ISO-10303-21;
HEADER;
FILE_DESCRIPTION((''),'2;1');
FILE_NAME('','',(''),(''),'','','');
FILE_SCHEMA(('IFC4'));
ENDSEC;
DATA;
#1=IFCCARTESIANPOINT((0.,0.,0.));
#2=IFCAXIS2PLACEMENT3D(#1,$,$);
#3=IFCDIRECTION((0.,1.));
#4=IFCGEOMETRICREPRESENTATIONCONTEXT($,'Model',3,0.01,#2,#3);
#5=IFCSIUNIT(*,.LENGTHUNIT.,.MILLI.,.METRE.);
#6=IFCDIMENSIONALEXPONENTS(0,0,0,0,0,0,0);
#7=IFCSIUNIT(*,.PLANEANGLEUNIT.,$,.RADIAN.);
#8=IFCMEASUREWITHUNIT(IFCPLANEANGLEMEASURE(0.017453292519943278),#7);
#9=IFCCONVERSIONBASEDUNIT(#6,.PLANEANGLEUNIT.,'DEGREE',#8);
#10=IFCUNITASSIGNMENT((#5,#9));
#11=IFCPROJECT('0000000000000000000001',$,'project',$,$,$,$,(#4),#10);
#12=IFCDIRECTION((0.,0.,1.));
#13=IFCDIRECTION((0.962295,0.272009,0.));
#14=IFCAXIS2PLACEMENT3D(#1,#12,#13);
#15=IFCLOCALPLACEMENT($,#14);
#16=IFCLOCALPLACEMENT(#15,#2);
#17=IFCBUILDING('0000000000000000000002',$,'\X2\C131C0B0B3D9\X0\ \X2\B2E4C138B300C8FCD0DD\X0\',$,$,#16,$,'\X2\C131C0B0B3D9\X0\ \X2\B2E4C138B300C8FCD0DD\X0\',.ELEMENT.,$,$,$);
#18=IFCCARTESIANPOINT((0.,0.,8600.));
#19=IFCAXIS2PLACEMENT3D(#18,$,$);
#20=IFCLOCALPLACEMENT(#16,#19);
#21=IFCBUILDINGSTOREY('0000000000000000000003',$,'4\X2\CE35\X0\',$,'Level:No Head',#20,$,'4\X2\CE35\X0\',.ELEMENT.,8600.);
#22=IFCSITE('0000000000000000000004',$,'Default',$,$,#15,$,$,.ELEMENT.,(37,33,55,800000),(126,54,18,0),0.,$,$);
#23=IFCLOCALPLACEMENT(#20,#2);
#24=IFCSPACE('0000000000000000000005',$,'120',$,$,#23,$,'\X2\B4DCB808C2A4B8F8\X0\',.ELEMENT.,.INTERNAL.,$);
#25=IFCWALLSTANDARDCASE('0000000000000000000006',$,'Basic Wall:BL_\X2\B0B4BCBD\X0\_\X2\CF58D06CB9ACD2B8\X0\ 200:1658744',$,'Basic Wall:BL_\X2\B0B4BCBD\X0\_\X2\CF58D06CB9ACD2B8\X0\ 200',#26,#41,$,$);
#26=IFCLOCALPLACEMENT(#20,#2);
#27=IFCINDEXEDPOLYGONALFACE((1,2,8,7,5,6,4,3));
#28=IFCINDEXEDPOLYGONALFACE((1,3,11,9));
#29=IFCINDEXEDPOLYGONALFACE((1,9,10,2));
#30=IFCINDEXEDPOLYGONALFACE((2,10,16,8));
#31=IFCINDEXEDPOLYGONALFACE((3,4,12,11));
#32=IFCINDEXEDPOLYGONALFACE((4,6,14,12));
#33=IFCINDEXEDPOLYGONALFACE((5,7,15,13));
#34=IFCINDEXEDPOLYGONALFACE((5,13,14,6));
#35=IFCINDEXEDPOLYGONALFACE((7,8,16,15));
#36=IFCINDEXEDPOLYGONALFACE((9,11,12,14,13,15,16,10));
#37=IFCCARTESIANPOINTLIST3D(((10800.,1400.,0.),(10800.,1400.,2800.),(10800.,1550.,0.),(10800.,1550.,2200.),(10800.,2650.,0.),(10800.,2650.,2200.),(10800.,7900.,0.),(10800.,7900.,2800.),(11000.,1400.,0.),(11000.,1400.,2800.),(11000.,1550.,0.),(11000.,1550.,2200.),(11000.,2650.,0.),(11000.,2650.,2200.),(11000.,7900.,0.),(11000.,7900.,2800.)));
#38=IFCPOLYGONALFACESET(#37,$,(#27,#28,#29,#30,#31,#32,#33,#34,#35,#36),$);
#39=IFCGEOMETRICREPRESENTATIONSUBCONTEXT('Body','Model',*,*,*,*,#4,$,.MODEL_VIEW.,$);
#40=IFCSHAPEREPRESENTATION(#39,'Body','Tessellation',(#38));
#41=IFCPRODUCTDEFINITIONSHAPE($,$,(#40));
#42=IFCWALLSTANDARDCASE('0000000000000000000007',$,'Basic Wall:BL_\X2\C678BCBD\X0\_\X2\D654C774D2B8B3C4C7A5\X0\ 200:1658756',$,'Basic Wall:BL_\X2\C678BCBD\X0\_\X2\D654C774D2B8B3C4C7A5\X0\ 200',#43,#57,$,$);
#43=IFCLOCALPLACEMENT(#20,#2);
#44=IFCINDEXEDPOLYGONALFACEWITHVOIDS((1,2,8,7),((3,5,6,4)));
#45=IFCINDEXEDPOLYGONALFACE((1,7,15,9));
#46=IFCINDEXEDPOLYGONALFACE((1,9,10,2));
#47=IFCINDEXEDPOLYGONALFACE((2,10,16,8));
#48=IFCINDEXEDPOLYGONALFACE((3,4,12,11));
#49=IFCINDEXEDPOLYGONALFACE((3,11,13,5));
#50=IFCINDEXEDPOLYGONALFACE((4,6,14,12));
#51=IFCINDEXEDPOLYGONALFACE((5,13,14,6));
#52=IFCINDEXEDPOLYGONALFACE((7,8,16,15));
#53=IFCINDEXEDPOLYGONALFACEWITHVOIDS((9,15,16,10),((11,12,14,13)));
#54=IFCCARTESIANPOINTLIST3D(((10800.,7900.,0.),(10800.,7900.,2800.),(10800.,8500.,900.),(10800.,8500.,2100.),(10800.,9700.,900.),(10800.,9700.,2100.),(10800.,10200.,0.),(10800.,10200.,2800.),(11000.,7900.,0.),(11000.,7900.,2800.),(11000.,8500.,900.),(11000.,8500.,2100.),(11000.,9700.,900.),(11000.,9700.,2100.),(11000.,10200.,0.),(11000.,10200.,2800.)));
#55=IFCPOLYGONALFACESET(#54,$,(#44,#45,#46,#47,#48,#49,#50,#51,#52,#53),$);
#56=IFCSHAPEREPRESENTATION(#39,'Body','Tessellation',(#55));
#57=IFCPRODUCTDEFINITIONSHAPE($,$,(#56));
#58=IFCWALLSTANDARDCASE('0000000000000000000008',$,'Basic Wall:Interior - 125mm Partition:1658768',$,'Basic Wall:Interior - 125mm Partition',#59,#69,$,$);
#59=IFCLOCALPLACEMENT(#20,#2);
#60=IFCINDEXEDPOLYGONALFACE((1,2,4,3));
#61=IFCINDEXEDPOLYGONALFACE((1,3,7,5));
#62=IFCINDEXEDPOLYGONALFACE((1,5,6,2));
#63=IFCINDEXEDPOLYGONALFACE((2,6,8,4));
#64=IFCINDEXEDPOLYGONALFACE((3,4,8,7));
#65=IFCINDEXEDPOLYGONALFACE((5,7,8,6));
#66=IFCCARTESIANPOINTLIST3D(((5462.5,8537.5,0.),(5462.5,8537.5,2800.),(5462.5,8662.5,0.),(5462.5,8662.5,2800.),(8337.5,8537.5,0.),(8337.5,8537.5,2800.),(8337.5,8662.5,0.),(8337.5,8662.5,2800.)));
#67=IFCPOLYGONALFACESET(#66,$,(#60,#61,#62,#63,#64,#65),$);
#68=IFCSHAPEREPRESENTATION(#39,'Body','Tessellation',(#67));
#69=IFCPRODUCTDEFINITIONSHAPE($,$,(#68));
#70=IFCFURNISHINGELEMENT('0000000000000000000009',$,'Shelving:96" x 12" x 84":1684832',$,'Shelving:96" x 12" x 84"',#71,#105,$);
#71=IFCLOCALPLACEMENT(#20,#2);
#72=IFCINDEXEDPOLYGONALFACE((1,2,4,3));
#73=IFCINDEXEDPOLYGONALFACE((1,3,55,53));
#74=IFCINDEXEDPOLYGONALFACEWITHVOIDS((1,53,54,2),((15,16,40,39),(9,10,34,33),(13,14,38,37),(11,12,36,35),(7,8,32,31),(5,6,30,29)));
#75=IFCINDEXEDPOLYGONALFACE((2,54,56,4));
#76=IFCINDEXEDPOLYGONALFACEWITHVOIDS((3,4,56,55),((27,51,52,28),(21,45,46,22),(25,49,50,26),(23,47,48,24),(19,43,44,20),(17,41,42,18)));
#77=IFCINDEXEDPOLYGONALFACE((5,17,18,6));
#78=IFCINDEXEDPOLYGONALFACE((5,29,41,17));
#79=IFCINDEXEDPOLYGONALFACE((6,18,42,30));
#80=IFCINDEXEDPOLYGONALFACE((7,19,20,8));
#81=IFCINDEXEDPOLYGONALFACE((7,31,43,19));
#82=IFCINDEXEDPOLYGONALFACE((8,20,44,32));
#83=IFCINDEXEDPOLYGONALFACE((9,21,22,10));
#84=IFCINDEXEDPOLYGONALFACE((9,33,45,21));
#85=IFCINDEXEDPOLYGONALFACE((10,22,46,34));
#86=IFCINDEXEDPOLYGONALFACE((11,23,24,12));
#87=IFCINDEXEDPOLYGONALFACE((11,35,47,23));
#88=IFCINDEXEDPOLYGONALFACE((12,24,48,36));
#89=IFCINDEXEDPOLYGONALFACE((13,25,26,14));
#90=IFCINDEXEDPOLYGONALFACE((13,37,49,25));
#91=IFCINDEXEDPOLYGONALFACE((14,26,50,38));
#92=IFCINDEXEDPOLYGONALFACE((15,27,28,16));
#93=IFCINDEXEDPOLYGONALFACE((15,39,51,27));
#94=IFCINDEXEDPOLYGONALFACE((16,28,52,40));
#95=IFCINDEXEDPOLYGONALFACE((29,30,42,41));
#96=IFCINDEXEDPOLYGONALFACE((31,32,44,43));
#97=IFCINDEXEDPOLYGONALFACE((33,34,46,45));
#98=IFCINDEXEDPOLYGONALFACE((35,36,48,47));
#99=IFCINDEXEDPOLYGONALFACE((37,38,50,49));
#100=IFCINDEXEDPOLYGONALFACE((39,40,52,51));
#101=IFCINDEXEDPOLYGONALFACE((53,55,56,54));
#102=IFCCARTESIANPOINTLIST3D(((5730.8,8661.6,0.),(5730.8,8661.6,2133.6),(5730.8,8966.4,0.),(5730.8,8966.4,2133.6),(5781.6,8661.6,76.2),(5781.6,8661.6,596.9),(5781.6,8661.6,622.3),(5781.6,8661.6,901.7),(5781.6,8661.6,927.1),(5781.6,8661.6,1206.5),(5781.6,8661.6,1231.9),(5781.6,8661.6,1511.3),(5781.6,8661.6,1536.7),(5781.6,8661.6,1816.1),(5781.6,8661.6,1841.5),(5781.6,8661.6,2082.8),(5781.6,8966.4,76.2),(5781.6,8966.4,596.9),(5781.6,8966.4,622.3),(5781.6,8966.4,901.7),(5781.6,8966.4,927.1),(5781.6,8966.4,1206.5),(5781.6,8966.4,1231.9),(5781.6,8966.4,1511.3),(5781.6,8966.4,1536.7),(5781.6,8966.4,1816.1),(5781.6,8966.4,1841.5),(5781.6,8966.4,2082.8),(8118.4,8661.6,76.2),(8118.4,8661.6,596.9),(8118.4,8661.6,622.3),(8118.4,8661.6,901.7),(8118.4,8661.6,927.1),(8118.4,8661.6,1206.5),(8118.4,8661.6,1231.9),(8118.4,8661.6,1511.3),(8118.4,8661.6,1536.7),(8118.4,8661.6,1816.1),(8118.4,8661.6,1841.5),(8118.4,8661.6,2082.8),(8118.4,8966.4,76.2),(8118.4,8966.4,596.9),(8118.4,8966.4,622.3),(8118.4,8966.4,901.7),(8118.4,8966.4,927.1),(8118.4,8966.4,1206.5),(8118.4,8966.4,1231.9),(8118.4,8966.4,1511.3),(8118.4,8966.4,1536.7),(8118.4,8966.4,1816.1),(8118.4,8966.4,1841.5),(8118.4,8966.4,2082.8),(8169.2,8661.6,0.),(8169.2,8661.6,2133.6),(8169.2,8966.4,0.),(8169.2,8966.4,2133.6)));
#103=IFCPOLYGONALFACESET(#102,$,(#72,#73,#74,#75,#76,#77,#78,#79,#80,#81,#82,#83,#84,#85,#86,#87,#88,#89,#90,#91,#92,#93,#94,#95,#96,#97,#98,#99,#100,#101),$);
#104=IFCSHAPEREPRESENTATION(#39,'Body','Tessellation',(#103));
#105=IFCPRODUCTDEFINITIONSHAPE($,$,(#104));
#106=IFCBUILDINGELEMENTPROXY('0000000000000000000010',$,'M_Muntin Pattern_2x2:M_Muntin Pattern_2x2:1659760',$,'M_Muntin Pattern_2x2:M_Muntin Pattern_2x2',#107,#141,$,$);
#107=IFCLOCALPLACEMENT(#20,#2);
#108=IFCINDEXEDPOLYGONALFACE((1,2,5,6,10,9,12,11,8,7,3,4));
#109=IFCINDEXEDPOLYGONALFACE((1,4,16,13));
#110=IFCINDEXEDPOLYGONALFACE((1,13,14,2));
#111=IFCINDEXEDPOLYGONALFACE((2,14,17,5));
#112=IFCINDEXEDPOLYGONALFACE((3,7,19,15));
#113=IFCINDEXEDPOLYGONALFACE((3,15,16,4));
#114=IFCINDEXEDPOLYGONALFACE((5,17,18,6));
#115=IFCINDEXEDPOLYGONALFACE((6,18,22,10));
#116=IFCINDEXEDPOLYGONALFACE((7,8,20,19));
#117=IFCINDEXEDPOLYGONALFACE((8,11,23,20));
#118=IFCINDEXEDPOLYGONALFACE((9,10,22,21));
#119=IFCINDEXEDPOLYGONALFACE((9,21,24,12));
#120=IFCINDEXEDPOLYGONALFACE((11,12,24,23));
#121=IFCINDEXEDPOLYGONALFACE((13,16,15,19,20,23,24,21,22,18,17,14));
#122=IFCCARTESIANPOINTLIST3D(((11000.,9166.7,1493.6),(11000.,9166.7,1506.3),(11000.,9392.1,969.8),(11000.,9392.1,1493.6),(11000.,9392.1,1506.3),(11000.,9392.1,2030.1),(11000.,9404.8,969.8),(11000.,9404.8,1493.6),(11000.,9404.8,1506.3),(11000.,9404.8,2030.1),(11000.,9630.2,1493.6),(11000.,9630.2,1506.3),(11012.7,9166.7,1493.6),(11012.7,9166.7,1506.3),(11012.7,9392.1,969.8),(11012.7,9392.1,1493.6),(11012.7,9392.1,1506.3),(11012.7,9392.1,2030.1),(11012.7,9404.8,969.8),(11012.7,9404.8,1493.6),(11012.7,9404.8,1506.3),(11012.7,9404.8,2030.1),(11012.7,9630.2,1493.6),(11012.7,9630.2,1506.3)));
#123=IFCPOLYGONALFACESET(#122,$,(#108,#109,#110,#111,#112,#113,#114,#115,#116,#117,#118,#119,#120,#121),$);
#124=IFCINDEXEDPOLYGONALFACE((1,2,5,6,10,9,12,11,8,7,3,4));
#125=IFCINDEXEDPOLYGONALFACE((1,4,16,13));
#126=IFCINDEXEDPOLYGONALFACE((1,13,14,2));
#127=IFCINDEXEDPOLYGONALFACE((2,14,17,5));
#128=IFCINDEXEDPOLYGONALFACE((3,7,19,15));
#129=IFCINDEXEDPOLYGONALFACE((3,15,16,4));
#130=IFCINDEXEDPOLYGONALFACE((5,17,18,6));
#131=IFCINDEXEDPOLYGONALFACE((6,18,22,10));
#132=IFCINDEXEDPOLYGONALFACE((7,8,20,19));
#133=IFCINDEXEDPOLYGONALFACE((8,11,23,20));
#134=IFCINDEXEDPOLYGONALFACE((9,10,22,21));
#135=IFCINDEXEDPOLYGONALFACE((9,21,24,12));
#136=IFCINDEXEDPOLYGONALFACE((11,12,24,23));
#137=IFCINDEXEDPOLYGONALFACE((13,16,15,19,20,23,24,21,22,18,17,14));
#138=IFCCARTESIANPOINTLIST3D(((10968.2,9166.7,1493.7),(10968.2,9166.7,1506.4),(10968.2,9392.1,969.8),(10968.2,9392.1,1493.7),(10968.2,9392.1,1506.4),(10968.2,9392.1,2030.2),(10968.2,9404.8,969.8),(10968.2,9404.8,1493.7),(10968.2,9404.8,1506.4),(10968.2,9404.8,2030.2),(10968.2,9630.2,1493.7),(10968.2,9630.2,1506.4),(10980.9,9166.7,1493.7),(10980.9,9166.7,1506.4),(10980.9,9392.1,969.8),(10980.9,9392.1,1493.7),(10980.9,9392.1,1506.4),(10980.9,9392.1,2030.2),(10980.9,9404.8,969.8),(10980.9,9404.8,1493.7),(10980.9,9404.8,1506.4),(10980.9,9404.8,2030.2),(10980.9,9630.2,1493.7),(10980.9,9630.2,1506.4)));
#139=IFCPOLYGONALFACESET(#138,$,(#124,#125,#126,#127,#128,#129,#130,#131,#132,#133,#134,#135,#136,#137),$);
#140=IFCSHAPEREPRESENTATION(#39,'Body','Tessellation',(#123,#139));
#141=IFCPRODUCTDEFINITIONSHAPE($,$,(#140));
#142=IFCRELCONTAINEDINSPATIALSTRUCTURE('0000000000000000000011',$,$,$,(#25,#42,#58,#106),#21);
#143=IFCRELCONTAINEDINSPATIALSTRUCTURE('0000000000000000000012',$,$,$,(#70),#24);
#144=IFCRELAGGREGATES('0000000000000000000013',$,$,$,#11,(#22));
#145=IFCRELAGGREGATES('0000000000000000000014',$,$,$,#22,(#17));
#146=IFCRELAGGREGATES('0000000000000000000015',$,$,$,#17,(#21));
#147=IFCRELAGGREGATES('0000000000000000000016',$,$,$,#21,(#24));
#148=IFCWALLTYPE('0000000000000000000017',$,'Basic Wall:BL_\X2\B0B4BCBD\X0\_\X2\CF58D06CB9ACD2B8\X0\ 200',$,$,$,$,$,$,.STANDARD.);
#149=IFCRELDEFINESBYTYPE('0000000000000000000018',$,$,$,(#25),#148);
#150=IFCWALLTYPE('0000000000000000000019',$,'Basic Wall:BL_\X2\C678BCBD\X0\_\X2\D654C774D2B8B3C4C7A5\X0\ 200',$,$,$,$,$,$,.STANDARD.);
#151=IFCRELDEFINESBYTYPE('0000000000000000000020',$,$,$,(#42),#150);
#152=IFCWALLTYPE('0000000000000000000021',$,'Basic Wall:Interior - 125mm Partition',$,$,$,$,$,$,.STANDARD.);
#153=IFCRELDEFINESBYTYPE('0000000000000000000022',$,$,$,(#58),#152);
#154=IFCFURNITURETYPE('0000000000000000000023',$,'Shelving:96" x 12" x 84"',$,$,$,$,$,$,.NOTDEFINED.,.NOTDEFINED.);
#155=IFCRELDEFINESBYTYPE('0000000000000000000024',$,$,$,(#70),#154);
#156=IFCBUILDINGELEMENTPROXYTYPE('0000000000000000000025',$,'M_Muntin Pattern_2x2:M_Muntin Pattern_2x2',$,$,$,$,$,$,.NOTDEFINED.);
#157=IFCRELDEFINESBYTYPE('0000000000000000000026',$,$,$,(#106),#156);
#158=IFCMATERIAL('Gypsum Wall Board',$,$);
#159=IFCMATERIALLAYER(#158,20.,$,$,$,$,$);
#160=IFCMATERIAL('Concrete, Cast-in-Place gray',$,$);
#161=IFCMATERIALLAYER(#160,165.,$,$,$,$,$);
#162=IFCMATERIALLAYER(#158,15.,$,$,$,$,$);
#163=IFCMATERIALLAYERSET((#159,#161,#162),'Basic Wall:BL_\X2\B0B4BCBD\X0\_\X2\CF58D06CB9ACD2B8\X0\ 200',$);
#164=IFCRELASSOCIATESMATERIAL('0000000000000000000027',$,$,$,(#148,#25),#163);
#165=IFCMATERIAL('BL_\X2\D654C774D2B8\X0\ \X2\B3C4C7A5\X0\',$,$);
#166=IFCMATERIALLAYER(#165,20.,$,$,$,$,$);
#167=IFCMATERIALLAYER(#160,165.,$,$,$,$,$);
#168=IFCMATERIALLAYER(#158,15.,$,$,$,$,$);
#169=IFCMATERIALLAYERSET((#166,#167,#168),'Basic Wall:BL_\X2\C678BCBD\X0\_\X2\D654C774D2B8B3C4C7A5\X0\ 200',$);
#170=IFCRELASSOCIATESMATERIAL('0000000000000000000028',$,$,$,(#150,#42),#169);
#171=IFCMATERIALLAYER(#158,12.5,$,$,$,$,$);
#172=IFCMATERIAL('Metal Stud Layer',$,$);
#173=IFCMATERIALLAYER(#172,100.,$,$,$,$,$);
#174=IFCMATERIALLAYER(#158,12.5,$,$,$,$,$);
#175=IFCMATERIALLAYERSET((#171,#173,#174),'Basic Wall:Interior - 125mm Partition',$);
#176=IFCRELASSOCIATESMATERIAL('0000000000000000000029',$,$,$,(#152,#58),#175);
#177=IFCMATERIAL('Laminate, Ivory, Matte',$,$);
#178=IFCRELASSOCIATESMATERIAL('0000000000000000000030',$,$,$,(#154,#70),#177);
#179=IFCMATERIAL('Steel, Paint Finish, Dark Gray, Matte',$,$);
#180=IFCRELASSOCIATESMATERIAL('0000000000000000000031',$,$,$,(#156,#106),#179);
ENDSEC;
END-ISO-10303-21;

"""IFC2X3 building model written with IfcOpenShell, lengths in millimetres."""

from ifc_helpers import new_model, entity, si_unit, converted_unit, direction, frame, frame_2d, origin, place, context, subcontext, project, spatial, polyline, rectangle, outline, extrude, source, transform, mapped, material, layer, layer_set, layer_usage, type_object, type_shapes, element, save


model = new_model("IFC2X3")

# Units and contexts
model_context = context("Model", 3, precision=0.01, world=origin(), true_north=direction((0.0, 1.0)))
body_context = subcontext(model_context, "Body", "Model", "MODEL_VIEW")
ifc_project = project(units=[si_unit("LENGTHUNIT", "METRE", prefix="MILLI"), converted_unit("PLANEANGLEUNIT", "DEGREE", entity("IfcPlaneAngleMeasure", 0.017453292519943278), si_unit("PLANEANGLEUNIT", "RADIAN"), dimensions=[0, 0, 0, 0, 0, 0, 0])], contexts=[model_context])

# Site, building, storey
site_placement = place(None, frame((0.0, 0.0, 0.0), z_axis=(0.0, 0.0, 1.0), x_axis=(0.962295, 0.272009, 0.0)))
site = spatial("IfcSite", under=ifc_project, at=site_placement, Name="Default", CompositionType="ELEMENT", RefLatitude=(37, 33, 55, 800000), RefLongitude=(126, 54, 18, 0), RefElevation=0.0)
building_placement = place(site_placement, origin())
building = spatial("IfcBuilding", under=site, at=building_placement, Name="성산동 다세대주택", LongName="성산동 다세대주택", CompositionType="ELEMENT")
storey_placement = place(building_placement, frame((0.0, 0.0, 8600.0)))
storey = spatial("IfcBuildingStorey", under=building, at=storey_placement, Name="4층", ObjectType="Level:No Head", LongName="4층", CompositionType="ELEMENT", Elevation=8600.0)

# Wall, openings
ifc_material_1 = material(Name="Gypsum Wall Board")
ifc_layer_1 = layer(ifc_material_1, 20.0)
ifc_material_2 = material(Name="Concrete, Cast-in-Place gray")
ifc_layer_2 = layer(ifc_material_2, 165.0)
ifc_layer_3 = layer(ifc_material_1, 15.0)
ifc_layer_set_1 = layer_set([ifc_layer_1, ifc_layer_2, ifc_layer_3], Name="Basic Wall:BL_내벽_콘크리트 200")
ifc_layer_usage_1 = layer_usage(ifc_layer_set_1, "AXIS2", "NEGATIVE", 100.0)
wall_type_1 = type_object("IfcWallType", Name="Basic Wall:BL_내벽_콘크리트 200", PredefinedType="STANDARD", material=ifc_layer_set_1)
wall_1_placement = place(storey_placement, frame((10900.0, 7900.0, 0.0), z_axis=(0.0, 0.0, 1.0), x_axis=(0.0, -1.0, 0.0)))
wall_1 = element("IfcWallStandardCase", 1, at=wall_1_placement, inside=storey, type_object=wall_type_1, material=ifc_layer_usage_1, Name="Basic Wall:BL_내벽_콘크리트 200:1658744", ObjectType="Basic Wall:BL_내벽_콘크리트 200", context=body_context, shape_type="SweptSolid", body=[
    extrude(rectangle(XDim=6500.0, YDim=200.0, at=frame_2d((3250.0, 0.0), x_axis=(1.0, 0.0))), origin(), (0.0, 0.0, 1.0), 2800.0),
])
opening_1_placement = place(wall_1_placement, origin())
element("IfcOpeningElement", 2, at=opening_1_placement, cuts=wall_1, ObjectType="Opening", context=body_context, shape_type="SweptSolid", body=[
    extrude(rectangle(XDim=2200.0, YDim=1100.0, at=frame_2d((0.0, 0.0), x_axis=(0.0, 1.0))), frame((5800.0, -1624.0, 3900.0), z_axis=(0.0, 1.0, 0.0), x_axis=(-1.0, 0.0, 0.0)), (0.0, 0.0, 1.0), 3048.0),
])
opening_2_placement = place(wall_1_placement, frame((5250.0, -100.0, 0.0)))
element("IfcOpeningElement", 3, at=opening_2_placement, cuts=wall_1, ObjectType="Opening", context=body_context, shape_type="SweptSolid", body=[
    extrude(rectangle(XDim=2200.0, YDim=1100.0, at=frame_2d((1100.0, 550.0), x_axis=(1.0, 0.0))), frame((0.0, 0.0, 0.0), z_axis=(0.0, 1.0, 0.0), x_axis=(0.0, 0.0, 1.0)), (0.0, 0.0, 1.0), 200.0),
])

# Wall, opening
ifc_material_3 = material(Name="BL_화이트 도장")
ifc_layer_4 = layer(ifc_material_3, 20.0)
ifc_layer_5 = layer(ifc_material_2, 165.0)
ifc_layer_6 = layer(ifc_material_1, 15.0)
ifc_layer_set_2 = layer_set([ifc_layer_4, ifc_layer_5, ifc_layer_6], Name="Basic Wall:BL_외벽_화이트도장 200")
ifc_layer_usage_2 = layer_usage(ifc_layer_set_2, "AXIS2", "NEGATIVE", 100.0)
wall_type_2 = type_object("IfcWallType", Name="Basic Wall:BL_외벽_화이트도장 200", PredefinedType="STANDARD", material=ifc_layer_set_2)
wall_2_placement = place(storey_placement, frame((10900.0, 10200.0, 0.0), z_axis=(0.0, 0.0, 1.0), x_axis=(0.0, -1.0, 0.0)))
wall_2 = element("IfcWallStandardCase", 4, at=wall_2_placement, inside=storey, type_object=wall_type_2, material=ifc_layer_usage_2, Name="Basic Wall:BL_외벽_화이트도장 200:1658756", ObjectType="Basic Wall:BL_외벽_화이트도장 200", context=body_context, shape_type="SweptSolid", body=[
    extrude(rectangle(XDim=2300.0, YDim=200.0, at=frame_2d((1150.0, 0.0), x_axis=(-1.0, 0.0))), origin(), (0.0, 0.0, 1.0), 2800.0),
])
opening_3_placement = place(wall_2_placement, frame((500.0, -100.0, 900.0)))
element("IfcOpeningElement", 5, at=opening_3_placement, cuts=wall_2, ObjectType="Opening", context=body_context, shape_type="SweptSolid", body=[
    extrude(rectangle(XDim=1200.0, YDim=1200.0, at=frame_2d((600.0, 600.0), x_axis=(-1.0, 0.0))), frame((0.0, 0.0, 0.0), z_axis=(0.0, 1.0, 0.0), x_axis=(0.0, 0.0, 1.0)), (0.0, 0.0, 1.0), 200.0),
])

# Wall
ifc_layer_7 = layer(ifc_material_1, 12.5)
ifc_material_4 = material(Name="Metal Stud Layer")
ifc_layer_8 = layer(ifc_material_4, 100.0)
ifc_layer_9 = layer(ifc_material_1, 12.5)
ifc_layer_set_3 = layer_set([ifc_layer_7, ifc_layer_8, ifc_layer_9], Name="Basic Wall:Interior - 125mm Partition")
ifc_layer_usage_3 = layer_usage(ifc_layer_set_3, "AXIS2", "NEGATIVE", 62.5)
wall_type_3 = type_object("IfcWallType", Name="Basic Wall:Interior - 125mm Partition", PredefinedType="STANDARD", material=ifc_layer_set_3)
wall_3_placement = place(storey_placement, frame((5462.5, 8600.0, 0.0)))
element("IfcWallStandardCase", 6, at=wall_3_placement, inside=storey, type_object=wall_type_3, material=ifc_layer_usage_3, Name="Basic Wall:Interior - 125mm Partition:1658768", ObjectType="Basic Wall:Interior - 125mm Partition", context=body_context, shape_type="SweptSolid", body=[
    extrude(rectangle(XDim=2875.0, YDim=125.0, at=frame_2d((1437.5, 0.0), x_axis=(-1.0, 0.0))), origin(), (0.0, 0.0, 1.0), 2800.0),
])

# Shared definitions
space_1_placement = place(storey_placement, origin())
space_1 = spatial("IfcSpace", under=storey, at=space_1_placement, Name="120", LongName="드레스룸", CompositionType="ELEMENT", InteriorOrExteriorSpace="INTERNAL")

# Furnishing element
ifc_material_5 = material(Name="Laminate, Ivory, Matte")
furniture_type_1 = type_object("IfcFurnitureType", Name="Shelving:96\" x 12\" x 84\"", AssemblyPlace="NOTDEFINED", material=ifc_material_5)
shared_shape_1 = source(origin(), body_context, "Body", "SweptSolid", [
    extrude(outline(polyline([(-1219.2, -1066.8), (1219.2, -1066.8), (1219.2, 1066.8), (-1219.2, 1066.8), (-1219.2, -1066.8)]), holes=[polyline([(-1168.4, 1016.0), (1168.4, 1016.0), (1168.4, 774.7), (-1168.4, 774.7), (-1168.4, 1016.0)]), polyline([(-1168.4, -990.6), (-1168.4, -469.9), (1168.4, -469.9), (1168.4, -990.6), (-1168.4, -990.6)]), polyline([(1168.4, 165.1), (-1168.4, 165.1), (-1168.4, 444.5), (1168.4, 444.5), (1168.4, 165.1)]), polyline([(-1168.4, 749.3), (1168.4, 749.3), (1168.4, 469.9), (-1168.4, 469.9), (-1168.4, 749.3)]), polyline([(-1168.4, 139.7), (1168.4, 139.7), (1168.4, -139.7), (-1168.4, -139.7), (-1168.4, 139.7)]), polyline([(-1168.4, -165.1), (1168.4, -165.1), (1168.4, -444.5), (-1168.4, -444.5), (-1168.4, -165.1)])]), frame((0.0, -457.2, 1066.8), z_axis=(0.0, 1.0, 0.0), x_axis=(-1.0, 0.0, 0.0)), (0.0, 0.0, 1.0), 304.8),
])
type_shapes(furniture_type_1, [shared_shape_1])
furnishing_1_placement = place(space_1_placement, frame((6950.0, 8509.2, 0.0), z_axis=(0.0, 0.0, 1.0), x_axis=(-1.0, 0.0, 0.0)))
element("IfcFurnishingElement", 7, at=furnishing_1_placement, inside=space_1, type_object=furniture_type_1, material=ifc_material_5, Name="Shelving:96\" x 12\" x 84\":1684832", ObjectType="Shelving:96\" x 12\" x 84\"", context=body_context, shape_type="MappedRepresentation", body=[
    mapped(shared_shape_1, transform((0.0, 0.0, 0.0), scale=1.0)),
])

# Building element proxy
ifc_material_6 = material(Name="Steel, Paint Finish, Dark Gray, Matte")
building_element_proxy_type_1 = type_object("IfcBuildingElementProxyType", Name="M_Muntin Pattern_2x2:M_Muntin Pattern_2x2", PredefinedType="NOTDEFINED", material=ifc_material_6)
shared_shape_2 = source(origin(), body_context, "Body", "SweptSolid", [
    extrude(outline(polyline([(6.4, -6.4), (530.1, -6.4), (530.1, 6.3), (6.4, 6.3), (6.4, 231.7), (-6.3, 231.7), (-6.3, 6.3), (-530.2, 6.3), (-530.2, -6.4), (-6.3, -6.4), (-6.3, -231.7), (6.4, -231.7), (6.4, -6.4)])), frame((0.0, 9.5, 530.1), z_axis=(0.0, 1.0, 0.0), x_axis=(0.0, 0.0, 1.0)), (0.0, 0.0, 1.0), 12.7),
    extrude(outline(polyline([(6.4, -6.4), (530.2, -6.4), (530.2, 6.3), (6.4, 6.3), (6.4, 231.7), (-6.3, 231.7), (-6.3, 6.3), (-530.2, 6.3), (-530.2, -6.4), (-6.3, -6.4), (-6.3, -231.7), (6.4, -231.7), (6.4, -6.4)])), frame((0.0, -22.2, 530.2), z_axis=(0.0, 1.0, 0.0), x_axis=(0.0, 0.0, 1.0)), (0.0, 0.0, 1.0), 12.7),
])
type_shapes(building_element_proxy_type_1, [shared_shape_2])
proxy_1_placement = place(storey_placement, frame((10990.5, 9398.4, 969.8), z_axis=(0.0, 0.0, 1.0), x_axis=(0.0, -1.0, 0.0)))
element("IfcBuildingElementProxy", 8, at=proxy_1_placement, inside=storey, type_object=building_element_proxy_type_1, material=ifc_material_6, Name="M_Muntin Pattern_2x2:M_Muntin Pattern_2x2:1659760", ObjectType="M_Muntin Pattern_2x2:M_Muntin Pattern_2x2", context=body_context, shape_type="MappedRepresentation", body=[
    mapped(shared_shape_2, transform((0.0, 0.0, 0.0), scale=1.0)),
])

save(model, "model.ifc")
